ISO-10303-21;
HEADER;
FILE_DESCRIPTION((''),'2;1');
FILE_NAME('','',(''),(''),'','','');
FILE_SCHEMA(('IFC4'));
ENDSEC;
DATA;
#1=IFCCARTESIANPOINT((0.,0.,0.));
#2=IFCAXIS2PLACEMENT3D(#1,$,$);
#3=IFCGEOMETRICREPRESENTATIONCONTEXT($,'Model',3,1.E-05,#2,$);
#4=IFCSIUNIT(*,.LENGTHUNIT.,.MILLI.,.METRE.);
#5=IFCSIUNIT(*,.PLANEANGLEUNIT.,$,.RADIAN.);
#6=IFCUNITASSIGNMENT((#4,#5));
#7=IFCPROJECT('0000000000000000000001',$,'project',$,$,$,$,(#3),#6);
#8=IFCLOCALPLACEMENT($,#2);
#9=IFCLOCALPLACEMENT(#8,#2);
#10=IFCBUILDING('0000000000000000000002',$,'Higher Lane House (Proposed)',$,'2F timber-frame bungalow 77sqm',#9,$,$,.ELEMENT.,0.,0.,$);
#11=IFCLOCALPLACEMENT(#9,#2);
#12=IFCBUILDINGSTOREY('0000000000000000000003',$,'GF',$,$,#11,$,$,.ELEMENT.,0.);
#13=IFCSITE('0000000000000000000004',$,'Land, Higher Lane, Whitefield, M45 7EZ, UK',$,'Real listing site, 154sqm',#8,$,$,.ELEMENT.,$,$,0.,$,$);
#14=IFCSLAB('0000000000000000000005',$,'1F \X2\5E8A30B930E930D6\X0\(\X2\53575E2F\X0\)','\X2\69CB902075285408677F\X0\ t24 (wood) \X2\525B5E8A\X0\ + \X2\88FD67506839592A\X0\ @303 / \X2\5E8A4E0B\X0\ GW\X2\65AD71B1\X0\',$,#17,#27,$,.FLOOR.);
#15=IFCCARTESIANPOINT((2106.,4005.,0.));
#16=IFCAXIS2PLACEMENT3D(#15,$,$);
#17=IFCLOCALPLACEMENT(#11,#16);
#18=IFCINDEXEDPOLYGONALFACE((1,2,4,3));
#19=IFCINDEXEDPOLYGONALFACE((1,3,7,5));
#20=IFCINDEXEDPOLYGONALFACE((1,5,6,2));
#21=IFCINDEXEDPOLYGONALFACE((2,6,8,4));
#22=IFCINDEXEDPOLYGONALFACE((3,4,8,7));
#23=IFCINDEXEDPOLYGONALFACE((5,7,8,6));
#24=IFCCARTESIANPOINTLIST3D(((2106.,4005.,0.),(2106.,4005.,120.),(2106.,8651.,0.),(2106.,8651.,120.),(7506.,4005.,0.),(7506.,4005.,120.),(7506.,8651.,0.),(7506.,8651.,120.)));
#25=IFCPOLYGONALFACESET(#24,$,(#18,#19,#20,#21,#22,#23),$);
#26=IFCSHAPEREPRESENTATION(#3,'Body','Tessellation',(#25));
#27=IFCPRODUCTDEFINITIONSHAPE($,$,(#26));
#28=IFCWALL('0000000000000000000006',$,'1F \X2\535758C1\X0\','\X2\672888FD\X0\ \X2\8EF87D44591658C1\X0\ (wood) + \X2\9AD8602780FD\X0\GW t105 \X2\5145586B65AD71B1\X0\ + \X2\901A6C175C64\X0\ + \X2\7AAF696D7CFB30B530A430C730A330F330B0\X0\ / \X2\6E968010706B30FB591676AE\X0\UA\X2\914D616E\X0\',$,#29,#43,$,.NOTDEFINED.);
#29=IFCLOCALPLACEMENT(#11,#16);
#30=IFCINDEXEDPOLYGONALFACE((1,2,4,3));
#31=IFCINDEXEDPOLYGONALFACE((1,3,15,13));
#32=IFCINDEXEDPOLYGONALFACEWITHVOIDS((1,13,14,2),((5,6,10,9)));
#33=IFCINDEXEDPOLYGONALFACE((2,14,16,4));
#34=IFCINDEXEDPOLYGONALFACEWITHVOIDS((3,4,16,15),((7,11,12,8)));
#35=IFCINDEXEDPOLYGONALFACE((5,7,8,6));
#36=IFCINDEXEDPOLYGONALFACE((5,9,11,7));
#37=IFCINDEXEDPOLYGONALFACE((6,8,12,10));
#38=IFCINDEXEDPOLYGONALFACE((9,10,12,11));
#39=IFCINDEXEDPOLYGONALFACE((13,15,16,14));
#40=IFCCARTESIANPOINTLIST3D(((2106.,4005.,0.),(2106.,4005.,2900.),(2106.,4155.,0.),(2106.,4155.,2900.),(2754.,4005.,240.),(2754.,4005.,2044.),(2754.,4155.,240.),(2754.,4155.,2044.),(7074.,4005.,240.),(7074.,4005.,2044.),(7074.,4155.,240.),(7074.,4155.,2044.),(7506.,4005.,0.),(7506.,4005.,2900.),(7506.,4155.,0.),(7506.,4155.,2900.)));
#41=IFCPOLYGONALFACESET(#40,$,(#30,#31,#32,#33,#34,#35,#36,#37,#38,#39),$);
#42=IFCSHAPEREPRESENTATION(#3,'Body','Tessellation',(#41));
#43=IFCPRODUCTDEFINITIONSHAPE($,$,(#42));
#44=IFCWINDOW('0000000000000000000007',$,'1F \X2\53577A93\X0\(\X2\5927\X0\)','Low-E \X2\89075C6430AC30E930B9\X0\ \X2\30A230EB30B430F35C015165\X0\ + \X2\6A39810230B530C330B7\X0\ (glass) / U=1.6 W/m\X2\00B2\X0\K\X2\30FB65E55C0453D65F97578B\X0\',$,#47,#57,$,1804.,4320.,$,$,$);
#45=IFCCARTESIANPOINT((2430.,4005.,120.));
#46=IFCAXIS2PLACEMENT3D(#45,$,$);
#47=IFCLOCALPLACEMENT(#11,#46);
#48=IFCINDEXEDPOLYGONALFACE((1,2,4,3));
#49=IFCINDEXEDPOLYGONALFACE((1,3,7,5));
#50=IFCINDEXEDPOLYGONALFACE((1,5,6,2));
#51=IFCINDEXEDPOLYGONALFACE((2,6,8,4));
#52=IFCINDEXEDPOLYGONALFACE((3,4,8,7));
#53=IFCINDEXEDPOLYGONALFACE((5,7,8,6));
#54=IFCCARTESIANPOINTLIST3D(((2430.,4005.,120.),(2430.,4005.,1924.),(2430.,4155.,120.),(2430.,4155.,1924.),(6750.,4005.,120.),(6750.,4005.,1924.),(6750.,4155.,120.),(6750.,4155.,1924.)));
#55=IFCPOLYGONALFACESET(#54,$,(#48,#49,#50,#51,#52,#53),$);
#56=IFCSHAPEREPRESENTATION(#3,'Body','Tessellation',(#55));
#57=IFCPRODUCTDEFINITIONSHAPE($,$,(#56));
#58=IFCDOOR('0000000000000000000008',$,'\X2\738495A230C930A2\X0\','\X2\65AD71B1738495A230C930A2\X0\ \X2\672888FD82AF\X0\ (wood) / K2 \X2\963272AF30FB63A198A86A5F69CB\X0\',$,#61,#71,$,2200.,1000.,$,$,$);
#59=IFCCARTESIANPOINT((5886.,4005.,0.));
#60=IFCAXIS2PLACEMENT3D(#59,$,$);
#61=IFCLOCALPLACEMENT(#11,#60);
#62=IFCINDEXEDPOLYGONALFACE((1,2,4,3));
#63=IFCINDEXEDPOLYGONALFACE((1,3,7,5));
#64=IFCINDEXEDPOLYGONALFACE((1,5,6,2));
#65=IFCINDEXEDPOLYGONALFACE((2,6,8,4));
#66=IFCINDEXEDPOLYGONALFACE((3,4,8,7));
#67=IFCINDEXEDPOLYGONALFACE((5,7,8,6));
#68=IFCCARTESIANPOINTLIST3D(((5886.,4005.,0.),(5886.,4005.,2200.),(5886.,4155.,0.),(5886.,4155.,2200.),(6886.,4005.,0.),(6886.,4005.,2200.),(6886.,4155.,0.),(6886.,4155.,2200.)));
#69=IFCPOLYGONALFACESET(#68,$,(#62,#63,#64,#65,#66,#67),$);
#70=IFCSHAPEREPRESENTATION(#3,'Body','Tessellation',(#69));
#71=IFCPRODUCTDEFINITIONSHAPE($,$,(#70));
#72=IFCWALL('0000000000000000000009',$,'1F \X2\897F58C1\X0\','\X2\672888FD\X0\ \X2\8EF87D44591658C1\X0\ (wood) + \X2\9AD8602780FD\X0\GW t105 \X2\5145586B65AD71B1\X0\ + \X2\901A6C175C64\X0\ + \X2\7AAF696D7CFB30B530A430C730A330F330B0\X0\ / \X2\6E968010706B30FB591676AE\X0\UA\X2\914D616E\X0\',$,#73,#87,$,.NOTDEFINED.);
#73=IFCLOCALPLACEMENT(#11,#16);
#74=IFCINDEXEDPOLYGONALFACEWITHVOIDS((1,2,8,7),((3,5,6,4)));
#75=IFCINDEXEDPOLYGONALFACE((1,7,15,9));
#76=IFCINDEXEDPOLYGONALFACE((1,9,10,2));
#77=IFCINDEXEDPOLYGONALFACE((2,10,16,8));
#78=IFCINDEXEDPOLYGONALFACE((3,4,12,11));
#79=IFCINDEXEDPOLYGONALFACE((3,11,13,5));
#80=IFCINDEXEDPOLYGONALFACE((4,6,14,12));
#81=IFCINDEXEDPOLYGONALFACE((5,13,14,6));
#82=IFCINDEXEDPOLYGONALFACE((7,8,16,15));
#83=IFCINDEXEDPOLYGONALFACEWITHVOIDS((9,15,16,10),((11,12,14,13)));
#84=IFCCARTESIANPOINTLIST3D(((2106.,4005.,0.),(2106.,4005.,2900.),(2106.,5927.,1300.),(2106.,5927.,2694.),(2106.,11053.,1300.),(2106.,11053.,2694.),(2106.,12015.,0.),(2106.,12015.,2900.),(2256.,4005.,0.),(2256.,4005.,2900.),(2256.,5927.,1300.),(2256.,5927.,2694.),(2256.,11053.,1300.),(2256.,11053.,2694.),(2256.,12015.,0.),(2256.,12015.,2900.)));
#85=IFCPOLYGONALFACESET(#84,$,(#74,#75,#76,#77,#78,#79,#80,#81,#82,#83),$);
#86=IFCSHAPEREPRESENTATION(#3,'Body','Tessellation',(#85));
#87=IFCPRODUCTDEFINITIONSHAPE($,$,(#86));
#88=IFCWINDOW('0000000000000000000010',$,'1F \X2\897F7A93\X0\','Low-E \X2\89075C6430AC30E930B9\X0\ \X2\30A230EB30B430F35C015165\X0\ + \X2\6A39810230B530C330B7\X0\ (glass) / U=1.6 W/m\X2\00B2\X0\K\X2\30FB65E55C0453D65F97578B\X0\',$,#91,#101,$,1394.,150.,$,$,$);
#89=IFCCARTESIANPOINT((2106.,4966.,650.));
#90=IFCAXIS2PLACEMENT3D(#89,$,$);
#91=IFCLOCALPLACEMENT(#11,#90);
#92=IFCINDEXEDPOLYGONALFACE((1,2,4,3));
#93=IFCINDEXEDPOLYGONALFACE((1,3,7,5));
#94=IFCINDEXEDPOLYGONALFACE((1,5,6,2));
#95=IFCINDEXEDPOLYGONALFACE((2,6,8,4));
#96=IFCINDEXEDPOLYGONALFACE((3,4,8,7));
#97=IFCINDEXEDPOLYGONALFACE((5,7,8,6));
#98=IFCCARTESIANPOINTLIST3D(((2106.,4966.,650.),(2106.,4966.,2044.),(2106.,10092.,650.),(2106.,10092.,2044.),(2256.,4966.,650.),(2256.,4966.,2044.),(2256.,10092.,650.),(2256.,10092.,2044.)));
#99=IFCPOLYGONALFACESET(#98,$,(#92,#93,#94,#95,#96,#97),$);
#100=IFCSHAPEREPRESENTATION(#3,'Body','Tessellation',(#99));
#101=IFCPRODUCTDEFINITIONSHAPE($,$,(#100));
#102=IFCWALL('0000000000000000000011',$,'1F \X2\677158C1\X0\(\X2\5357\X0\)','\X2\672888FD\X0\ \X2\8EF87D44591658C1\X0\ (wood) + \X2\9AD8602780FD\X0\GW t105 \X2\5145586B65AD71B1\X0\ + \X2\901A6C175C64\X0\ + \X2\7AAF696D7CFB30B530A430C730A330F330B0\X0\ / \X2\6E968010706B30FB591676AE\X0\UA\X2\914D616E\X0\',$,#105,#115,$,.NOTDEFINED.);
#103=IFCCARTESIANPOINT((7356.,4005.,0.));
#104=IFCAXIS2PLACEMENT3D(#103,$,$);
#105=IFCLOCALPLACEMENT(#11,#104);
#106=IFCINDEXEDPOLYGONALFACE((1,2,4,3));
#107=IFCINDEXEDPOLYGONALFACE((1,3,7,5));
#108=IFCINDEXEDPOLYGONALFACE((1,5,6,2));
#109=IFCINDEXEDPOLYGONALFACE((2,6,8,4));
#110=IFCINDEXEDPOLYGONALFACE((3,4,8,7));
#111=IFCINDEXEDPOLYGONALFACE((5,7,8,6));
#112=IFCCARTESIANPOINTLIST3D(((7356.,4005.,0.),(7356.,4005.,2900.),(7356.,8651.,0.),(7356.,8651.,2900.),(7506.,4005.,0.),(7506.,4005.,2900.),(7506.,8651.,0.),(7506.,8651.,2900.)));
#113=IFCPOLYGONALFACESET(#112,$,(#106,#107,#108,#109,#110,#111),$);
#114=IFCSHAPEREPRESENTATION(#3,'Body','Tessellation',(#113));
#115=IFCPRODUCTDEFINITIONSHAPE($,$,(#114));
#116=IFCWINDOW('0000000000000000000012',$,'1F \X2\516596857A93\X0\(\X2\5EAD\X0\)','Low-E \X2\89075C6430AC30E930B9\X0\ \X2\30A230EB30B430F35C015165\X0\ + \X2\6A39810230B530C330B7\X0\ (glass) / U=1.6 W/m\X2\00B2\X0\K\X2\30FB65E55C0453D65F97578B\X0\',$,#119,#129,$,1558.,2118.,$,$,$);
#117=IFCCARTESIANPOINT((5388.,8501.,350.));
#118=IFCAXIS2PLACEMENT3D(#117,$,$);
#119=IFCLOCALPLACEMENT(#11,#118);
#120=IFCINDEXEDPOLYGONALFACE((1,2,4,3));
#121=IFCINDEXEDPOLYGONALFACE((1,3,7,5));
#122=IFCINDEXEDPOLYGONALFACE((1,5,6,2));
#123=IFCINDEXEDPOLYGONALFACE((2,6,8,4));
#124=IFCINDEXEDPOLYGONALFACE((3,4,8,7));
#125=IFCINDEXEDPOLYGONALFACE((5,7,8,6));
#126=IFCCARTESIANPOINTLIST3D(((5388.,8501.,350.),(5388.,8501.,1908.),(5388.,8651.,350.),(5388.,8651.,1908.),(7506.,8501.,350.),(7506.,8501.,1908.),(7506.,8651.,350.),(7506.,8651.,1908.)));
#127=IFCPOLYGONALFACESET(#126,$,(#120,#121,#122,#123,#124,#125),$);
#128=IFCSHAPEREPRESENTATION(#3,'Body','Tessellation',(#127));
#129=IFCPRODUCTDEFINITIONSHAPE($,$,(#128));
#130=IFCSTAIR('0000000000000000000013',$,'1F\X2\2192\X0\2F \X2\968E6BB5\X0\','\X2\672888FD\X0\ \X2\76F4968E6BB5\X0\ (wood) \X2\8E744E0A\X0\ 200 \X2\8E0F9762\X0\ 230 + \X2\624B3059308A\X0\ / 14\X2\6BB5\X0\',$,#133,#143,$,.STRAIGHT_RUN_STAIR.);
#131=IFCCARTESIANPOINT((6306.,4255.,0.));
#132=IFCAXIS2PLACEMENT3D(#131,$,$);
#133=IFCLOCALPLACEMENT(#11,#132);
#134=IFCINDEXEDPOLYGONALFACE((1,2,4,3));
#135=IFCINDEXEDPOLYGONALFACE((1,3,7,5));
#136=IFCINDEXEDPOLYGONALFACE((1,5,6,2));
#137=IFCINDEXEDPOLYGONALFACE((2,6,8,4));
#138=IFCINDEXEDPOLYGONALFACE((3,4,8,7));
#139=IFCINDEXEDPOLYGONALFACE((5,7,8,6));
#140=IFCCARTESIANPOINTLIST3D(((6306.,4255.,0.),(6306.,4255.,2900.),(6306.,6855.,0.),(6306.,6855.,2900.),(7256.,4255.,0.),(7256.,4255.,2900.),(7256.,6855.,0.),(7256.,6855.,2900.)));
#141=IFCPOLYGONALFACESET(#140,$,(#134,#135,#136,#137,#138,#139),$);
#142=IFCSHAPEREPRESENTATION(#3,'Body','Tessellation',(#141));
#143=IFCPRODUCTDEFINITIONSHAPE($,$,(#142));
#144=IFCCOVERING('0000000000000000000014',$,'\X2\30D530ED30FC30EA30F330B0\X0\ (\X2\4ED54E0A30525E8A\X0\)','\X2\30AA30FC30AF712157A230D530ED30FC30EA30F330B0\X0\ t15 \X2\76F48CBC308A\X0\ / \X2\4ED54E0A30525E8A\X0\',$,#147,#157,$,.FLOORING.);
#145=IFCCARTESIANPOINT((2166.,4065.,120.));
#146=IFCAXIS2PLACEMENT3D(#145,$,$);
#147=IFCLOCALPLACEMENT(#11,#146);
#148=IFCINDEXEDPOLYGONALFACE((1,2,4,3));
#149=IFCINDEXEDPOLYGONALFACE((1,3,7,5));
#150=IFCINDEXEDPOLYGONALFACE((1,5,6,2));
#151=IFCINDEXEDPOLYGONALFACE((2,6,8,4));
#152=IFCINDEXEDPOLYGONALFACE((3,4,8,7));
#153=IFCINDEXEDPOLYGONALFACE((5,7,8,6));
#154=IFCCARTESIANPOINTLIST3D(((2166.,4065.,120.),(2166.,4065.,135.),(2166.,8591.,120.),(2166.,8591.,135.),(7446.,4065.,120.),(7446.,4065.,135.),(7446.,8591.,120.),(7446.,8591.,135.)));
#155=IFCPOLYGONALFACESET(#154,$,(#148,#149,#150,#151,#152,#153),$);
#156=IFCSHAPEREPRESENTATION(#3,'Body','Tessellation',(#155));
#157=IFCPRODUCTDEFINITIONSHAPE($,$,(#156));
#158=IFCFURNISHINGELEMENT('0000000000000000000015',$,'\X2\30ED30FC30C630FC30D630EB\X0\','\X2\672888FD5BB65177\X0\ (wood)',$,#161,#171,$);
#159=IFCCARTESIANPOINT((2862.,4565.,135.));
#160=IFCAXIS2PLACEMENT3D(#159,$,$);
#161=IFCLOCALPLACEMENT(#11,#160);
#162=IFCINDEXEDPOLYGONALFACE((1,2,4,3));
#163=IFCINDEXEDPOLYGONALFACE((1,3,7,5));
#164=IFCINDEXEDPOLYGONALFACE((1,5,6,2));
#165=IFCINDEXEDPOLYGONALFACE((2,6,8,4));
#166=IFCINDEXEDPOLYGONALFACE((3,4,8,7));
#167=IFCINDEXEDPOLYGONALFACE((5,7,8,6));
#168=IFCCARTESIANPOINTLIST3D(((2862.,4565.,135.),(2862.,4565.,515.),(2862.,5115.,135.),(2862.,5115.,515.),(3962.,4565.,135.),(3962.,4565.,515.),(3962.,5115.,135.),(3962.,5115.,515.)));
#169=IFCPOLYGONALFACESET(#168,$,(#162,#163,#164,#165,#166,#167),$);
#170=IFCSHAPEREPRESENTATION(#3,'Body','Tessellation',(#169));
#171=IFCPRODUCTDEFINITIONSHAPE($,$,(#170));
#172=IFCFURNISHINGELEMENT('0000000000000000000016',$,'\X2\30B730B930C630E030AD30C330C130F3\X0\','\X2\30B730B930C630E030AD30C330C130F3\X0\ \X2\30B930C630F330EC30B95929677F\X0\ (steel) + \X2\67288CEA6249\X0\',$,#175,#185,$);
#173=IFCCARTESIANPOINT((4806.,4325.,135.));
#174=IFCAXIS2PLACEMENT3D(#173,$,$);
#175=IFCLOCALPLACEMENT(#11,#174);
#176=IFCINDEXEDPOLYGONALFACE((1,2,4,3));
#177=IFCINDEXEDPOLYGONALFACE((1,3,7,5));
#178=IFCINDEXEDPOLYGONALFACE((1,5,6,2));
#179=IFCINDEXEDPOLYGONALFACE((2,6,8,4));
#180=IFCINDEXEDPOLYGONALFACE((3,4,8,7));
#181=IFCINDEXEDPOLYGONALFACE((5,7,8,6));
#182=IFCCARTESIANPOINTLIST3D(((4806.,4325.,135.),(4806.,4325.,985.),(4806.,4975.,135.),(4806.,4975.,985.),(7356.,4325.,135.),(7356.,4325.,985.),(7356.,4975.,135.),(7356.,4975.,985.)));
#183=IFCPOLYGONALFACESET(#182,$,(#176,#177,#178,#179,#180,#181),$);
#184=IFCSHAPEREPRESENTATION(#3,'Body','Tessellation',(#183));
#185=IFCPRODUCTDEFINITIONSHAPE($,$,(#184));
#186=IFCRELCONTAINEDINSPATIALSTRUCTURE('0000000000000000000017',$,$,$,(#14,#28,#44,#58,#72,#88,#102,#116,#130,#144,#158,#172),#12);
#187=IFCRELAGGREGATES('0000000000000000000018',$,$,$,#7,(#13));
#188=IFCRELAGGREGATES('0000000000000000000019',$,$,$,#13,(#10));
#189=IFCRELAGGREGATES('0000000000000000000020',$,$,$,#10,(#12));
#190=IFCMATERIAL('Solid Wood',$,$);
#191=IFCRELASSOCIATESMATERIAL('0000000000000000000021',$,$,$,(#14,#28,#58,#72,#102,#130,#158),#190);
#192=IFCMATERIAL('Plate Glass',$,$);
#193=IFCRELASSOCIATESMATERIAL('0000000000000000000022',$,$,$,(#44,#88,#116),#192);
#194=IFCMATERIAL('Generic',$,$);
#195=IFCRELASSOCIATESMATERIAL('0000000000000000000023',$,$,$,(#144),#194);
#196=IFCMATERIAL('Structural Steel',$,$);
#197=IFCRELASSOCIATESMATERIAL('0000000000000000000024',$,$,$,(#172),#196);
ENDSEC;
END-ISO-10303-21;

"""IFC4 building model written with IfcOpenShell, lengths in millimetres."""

from ifc_helpers import new_model, si_unit, frame, frame_2d, origin, place, context, project, spatial, rectangle, extrude, material, element, fill, save


model = new_model("IFC4")

# Units and contexts
model_context = context("Model", 3, precision=1e-05, world=origin())
ifc_project = project(units=[si_unit("LENGTHUNIT", "METRE", prefix="MILLI"), si_unit("PLANEANGLEUNIT", "RADIAN")], contexts=[model_context])

# Site, building, storey
site_placement = place(None, origin())
site = spatial("IfcSite", under=ifc_project, at=site_placement, Name="Land, Higher Lane, Whitefield, M45 7EZ, UK", ObjectType="Real listing site, 154sqm", CompositionType="ELEMENT", RefElevation=0.0)
building_placement = place(site_placement, origin())
building = spatial("IfcBuilding", under=site, at=building_placement, Name="Higher Lane House (Proposed)", ObjectType="2F timber-frame bungalow 77sqm", CompositionType="ELEMENT", ElevationOfRefHeight=0.0, ElevationOfTerrain=0.0)
storey_placement = place(building_placement, origin())
storey = spatial("IfcBuildingStorey", under=building, at=storey_placement, Name="GF", CompositionType="ELEMENT", Elevation=0.0)

# Slab
ifc_material_1 = material(Name="Solid Wood")
slab_1_placement = place(storey_placement, frame((2106.0, 4005.0, 0.0)))
element("IfcSlab", 1, at=slab_1_placement, inside=storey, material=ifc_material_1, Name="1F 床スラブ(南帯)", Description="構造用合板 t24 (wood) 剛床 + 製材根太 @303 / 床下 GW断熱", PredefinedType="FLOOR", context=model_context, shape_type="SweptSolid", body=[
    extrude(rectangle(XDim=5400.0, YDim=4646.0, at=frame_2d((2700.0, 2323.0))), frame((2106.0, 4005.0, 0.0)), (0.0, 0.0, 1.0), 120.0),
])

# Wall, openings, window, door
wall_1_placement = place(storey_placement, frame((2106.0, 4005.0, 0.0)))
wall_1 = element("IfcWall", 2, at=wall_1_placement, inside=storey, material=ifc_material_1, Name="1F 南壁", Description="木製 軸組外壁 (wood) + 高性能GW t105 充填断熱 + 通気層 + 窯業系サイディング / 準耐火・外皮UA配慮", PredefinedType="NOTDEFINED", context=model_context, shape_type="SweptSolid", body=[
    extrude(rectangle(XDim=5400.0, YDim=150.0, at=frame_2d((2700.0, 75.0))), frame((2106.0, 4005.0, 0.0)), (0.0, 0.0, 1.0), 2900.0),
])
opening_1_placement = place(storey_placement, frame((2430.0, 4005.0, 120.0)))
opening_1 = element("IfcOpeningElement", 3, at=opening_1_placement, cuts=wall_1, PredefinedType="NOTDEFINED", context=model_context, shape_type="SweptSolid", body=[
    extrude(rectangle(XDim=4320.0, YDim=150.0, at=frame_2d((2160.0, 75.0))), frame((2430.0, 4005.0, 120.0)), (0.0, 0.0, 1.0), 1804.0),
])
opening_2_placement = place(storey_placement, frame((5886.0, 4005.0, 0.0)))
opening_2 = element("IfcOpeningElement", 4, at=opening_2_placement, cuts=wall_1, PredefinedType="NOTDEFINED", context=model_context, shape_type="SweptSolid", body=[
    extrude(rectangle(XDim=1000.0, YDim=150.0, at=frame_2d((500.0, 75.0))), frame((5886.0, 4005.0, 0.0)), (0.0, 0.0, 1.0), 2200.0),
])
ifc_material_2 = material(Name="Plate Glass")
window_1_placement = place(storey_placement, frame((2430.0, 4005.0, 120.0)))
window_1 = element("IfcWindow", 5, at=window_1_placement, inside=storey, material=ifc_material_2, Name="1F 南窓(大)", Description="Low-E 複層ガラス アルゴン封入 + 樹脂サッシ (glass) / U=1.6 W/m²K・日射取得型", OverallHeight=1804.0, OverallWidth=4320.0, context=model_context, shape_type="SweptSolid", body=[
    extrude(rectangle(XDim=4320.0, YDim=150.0, at=frame_2d((2160.0, 75.0))), frame((2430.0, 4005.0, 120.0)), (0.0, 0.0, 1.0), 1804.0),
])
fill(opening_1, window_1)
door_1_placement = place(storey_placement, frame((5886.0, 4005.0, 0.0)))
door_1 = element("IfcDoor", 6, at=door_1_placement, inside=storey, material=ifc_material_1, Name="玄関ドア", Description="断熱玄関ドア 木製芯 (wood) / K2 防犯・採風機構", OverallHeight=2200.0, OverallWidth=1000.0, context=model_context, shape_type="SweptSolid", body=[
    extrude(rectangle(XDim=1000.0, YDim=150.0, at=frame_2d((500.0, 75.0))), frame((5886.0, 4005.0, 0.0)), (0.0, 0.0, 1.0), 2200.0),
])
fill(opening_2, door_1)

# Walls, openings, windows
wall_2_placement = place(storey_placement, frame((2106.0, 4005.0, 0.0)))
wall_2 = element("IfcWall", 7, at=wall_2_placement, inside=storey, material=ifc_material_1, Name="1F 西壁", Description="木製 軸組外壁 (wood) + 高性能GW t105 充填断熱 + 通気層 + 窯業系サイディング / 準耐火・外皮UA配慮", PredefinedType="NOTDEFINED", context=model_context, shape_type="SweptSolid", body=[
    extrude(rectangle(XDim=150.0, YDim=8010.0, at=frame_2d((75.0, 4005.0))), frame((2106.0, 4005.0, 0.0)), (0.0, 0.0, 1.0), 2900.0),
])
opening_3_placement = place(storey_placement, frame((2106.0, 4966.0, 650.0)))
opening_3 = element("IfcOpeningElement", 8, at=opening_3_placement, cuts=wall_2, PredefinedType="NOTDEFINED", context=model_context, shape_type="SweptSolid", body=[
    extrude(rectangle(XDim=150.0, YDim=5126.0, at=frame_2d((75.0, 2563.0))), frame((2106.0, 4966.0, 650.0)), (0.0, 0.0, 1.0), 1394.0),
])
window_2_placement = place(storey_placement, frame((2106.0, 4966.0, 650.0)))
window_2 = element("IfcWindow", 9, at=window_2_placement, inside=storey, material=ifc_material_2, Name="1F 西窓", Description="Low-E 複層ガラス アルゴン封入 + 樹脂サッシ (glass) / U=1.6 W/m²K・日射取得型", OverallHeight=1394.0, OverallWidth=150.0, context=model_context, shape_type="SweptSolid", body=[
    extrude(rectangle(XDim=150.0, YDim=5126.0, at=frame_2d((75.0, 2563.0))), frame((2106.0, 4966.0, 650.0)), (0.0, 0.0, 1.0), 1394.0),
])
fill(opening_3, window_2)
wall_3_placement = place(storey_placement, frame((7356.0, 4005.0, 0.0)))
wall_3 = element("IfcWall", 10, at=wall_3_placement, inside=storey, material=ifc_material_1, Name="1F 東壁(南)", Description="木製 軸組外壁 (wood) + 高性能GW t105 充填断熱 + 通気層 + 窯業系サイディング / 準耐火・外皮UA配慮", PredefinedType="NOTDEFINED", context=model_context, shape_type="SweptSolid", body=[
    extrude(rectangle(XDim=150.0, YDim=4646.0, at=frame_2d((75.0, 2323.0))), frame((7356.0, 4005.0, 0.0)), (0.0, 0.0, 1.0), 2900.0),
])
opening_4_placement = place(storey_placement, frame((5388.0, 8501.0, 350.0)))
opening_4 = element("IfcOpeningElement", 11, at=opening_4_placement, cuts=wall_3, PredefinedType="NOTDEFINED", context=model_context, shape_type="SweptSolid", body=[
    extrude(rectangle(XDim=2118.0, YDim=150.0, at=frame_2d((1059.0, 75.0))), frame((5388.0, 8501.0, 350.0)), (0.0, 0.0, 1.0), 1558.0),
])
window_3_placement = place(storey_placement, frame((5388.0, 8501.0, 350.0)))
window_3 = element("IfcWindow", 12, at=window_3_placement, inside=storey, material=ifc_material_2, Name="1F 入隅窓(庭)", Description="Low-E 複層ガラス アルゴン封入 + 樹脂サッシ (glass) / U=1.6 W/m²K・日射取得型", OverallHeight=1558.0, OverallWidth=2118.0, context=model_context, shape_type="SweptSolid", body=[
    extrude(rectangle(XDim=2118.0, YDim=150.0, at=frame_2d((1059.0, 75.0))), frame((5388.0, 8501.0, 350.0)), (0.0, 0.0, 1.0), 1558.0),
])
fill(opening_4, window_3)

# Stair
stair_placement = place(storey_placement, frame((6306.0, 4255.0, 0.0)))
element("IfcStair", 13, at=stair_placement, inside=storey, material=ifc_material_1, Name="1F→2F 階段", Description="木製 直階段 (wood) 蹴上 200 踏面 230 + 手すり / 14段", PredefinedType="STRAIGHT_RUN_STAIR", context=model_context, shape_type="SweptSolid", body=[
    extrude(rectangle(XDim=950.0, YDim=2600.0, at=frame_2d((475.0, 1300.0))), frame((6306.0, 4255.0, 0.0)), (0.0, 0.0, 1.0), 2900.0),
])

# Covering
ifc_material_3 = material(Name="Generic")
covering_placement = place(storey_placement, frame((2166.0, 4065.0, 120.0)))
element("IfcCovering", 14, at=covering_placement, inside=storey, material=ifc_material_3, Name="フローリング (仕上げ床)", Description="オーク無垢フローリング t15 直貼り / 仕上げ床", PredefinedType="FLOORING", context=model_context, shape_type="SweptSolid", body=[
    extrude(rectangle(XDim=5280.0, YDim=4526.0, at=frame_2d((2640.0, 2263.0))), frame((2166.0, 4065.0, 120.0)), (0.0, 0.0, 1.0), 15.0),
])

# Furnishing elements
furnishing_1_placement = place(storey_placement, frame((2862.0, 4565.0, 135.0)))
element("IfcFurnishingElement", 15, at=furnishing_1_placement, inside=storey, material=ifc_material_1, Name="ローテーブル", Description="木製家具 (wood)", context=model_context, shape_type="SweptSolid", body=[
    extrude(rectangle(XDim=1100.0, YDim=550.0, at=frame_2d((550.0, 275.0))), frame((2862.0, 4565.0, 135.0)), (0.0, 0.0, 1.0), 380.0),
])
ifc_material_4 = material(Name="Structural Steel")
furnishing_2_placement = place(storey_placement, frame((4806.0, 4325.0, 135.0)))
element("IfcFurnishingElement", 16, at=furnishing_2_placement, inside=storey, material=ifc_material_4, Name="システムキッチン", Description="システムキッチン ステンレス天板 (steel) + 木質扉", context=model_context, shape_type="SweptSolid", body=[
    extrude(rectangle(XDim=2550.0, YDim=650.0, at=frame_2d((1275.0, 325.0))), frame((4806.0, 4325.0, 135.0)), (0.0, 0.0, 1.0), 850.0),
])

save(model, "model.ifc")
